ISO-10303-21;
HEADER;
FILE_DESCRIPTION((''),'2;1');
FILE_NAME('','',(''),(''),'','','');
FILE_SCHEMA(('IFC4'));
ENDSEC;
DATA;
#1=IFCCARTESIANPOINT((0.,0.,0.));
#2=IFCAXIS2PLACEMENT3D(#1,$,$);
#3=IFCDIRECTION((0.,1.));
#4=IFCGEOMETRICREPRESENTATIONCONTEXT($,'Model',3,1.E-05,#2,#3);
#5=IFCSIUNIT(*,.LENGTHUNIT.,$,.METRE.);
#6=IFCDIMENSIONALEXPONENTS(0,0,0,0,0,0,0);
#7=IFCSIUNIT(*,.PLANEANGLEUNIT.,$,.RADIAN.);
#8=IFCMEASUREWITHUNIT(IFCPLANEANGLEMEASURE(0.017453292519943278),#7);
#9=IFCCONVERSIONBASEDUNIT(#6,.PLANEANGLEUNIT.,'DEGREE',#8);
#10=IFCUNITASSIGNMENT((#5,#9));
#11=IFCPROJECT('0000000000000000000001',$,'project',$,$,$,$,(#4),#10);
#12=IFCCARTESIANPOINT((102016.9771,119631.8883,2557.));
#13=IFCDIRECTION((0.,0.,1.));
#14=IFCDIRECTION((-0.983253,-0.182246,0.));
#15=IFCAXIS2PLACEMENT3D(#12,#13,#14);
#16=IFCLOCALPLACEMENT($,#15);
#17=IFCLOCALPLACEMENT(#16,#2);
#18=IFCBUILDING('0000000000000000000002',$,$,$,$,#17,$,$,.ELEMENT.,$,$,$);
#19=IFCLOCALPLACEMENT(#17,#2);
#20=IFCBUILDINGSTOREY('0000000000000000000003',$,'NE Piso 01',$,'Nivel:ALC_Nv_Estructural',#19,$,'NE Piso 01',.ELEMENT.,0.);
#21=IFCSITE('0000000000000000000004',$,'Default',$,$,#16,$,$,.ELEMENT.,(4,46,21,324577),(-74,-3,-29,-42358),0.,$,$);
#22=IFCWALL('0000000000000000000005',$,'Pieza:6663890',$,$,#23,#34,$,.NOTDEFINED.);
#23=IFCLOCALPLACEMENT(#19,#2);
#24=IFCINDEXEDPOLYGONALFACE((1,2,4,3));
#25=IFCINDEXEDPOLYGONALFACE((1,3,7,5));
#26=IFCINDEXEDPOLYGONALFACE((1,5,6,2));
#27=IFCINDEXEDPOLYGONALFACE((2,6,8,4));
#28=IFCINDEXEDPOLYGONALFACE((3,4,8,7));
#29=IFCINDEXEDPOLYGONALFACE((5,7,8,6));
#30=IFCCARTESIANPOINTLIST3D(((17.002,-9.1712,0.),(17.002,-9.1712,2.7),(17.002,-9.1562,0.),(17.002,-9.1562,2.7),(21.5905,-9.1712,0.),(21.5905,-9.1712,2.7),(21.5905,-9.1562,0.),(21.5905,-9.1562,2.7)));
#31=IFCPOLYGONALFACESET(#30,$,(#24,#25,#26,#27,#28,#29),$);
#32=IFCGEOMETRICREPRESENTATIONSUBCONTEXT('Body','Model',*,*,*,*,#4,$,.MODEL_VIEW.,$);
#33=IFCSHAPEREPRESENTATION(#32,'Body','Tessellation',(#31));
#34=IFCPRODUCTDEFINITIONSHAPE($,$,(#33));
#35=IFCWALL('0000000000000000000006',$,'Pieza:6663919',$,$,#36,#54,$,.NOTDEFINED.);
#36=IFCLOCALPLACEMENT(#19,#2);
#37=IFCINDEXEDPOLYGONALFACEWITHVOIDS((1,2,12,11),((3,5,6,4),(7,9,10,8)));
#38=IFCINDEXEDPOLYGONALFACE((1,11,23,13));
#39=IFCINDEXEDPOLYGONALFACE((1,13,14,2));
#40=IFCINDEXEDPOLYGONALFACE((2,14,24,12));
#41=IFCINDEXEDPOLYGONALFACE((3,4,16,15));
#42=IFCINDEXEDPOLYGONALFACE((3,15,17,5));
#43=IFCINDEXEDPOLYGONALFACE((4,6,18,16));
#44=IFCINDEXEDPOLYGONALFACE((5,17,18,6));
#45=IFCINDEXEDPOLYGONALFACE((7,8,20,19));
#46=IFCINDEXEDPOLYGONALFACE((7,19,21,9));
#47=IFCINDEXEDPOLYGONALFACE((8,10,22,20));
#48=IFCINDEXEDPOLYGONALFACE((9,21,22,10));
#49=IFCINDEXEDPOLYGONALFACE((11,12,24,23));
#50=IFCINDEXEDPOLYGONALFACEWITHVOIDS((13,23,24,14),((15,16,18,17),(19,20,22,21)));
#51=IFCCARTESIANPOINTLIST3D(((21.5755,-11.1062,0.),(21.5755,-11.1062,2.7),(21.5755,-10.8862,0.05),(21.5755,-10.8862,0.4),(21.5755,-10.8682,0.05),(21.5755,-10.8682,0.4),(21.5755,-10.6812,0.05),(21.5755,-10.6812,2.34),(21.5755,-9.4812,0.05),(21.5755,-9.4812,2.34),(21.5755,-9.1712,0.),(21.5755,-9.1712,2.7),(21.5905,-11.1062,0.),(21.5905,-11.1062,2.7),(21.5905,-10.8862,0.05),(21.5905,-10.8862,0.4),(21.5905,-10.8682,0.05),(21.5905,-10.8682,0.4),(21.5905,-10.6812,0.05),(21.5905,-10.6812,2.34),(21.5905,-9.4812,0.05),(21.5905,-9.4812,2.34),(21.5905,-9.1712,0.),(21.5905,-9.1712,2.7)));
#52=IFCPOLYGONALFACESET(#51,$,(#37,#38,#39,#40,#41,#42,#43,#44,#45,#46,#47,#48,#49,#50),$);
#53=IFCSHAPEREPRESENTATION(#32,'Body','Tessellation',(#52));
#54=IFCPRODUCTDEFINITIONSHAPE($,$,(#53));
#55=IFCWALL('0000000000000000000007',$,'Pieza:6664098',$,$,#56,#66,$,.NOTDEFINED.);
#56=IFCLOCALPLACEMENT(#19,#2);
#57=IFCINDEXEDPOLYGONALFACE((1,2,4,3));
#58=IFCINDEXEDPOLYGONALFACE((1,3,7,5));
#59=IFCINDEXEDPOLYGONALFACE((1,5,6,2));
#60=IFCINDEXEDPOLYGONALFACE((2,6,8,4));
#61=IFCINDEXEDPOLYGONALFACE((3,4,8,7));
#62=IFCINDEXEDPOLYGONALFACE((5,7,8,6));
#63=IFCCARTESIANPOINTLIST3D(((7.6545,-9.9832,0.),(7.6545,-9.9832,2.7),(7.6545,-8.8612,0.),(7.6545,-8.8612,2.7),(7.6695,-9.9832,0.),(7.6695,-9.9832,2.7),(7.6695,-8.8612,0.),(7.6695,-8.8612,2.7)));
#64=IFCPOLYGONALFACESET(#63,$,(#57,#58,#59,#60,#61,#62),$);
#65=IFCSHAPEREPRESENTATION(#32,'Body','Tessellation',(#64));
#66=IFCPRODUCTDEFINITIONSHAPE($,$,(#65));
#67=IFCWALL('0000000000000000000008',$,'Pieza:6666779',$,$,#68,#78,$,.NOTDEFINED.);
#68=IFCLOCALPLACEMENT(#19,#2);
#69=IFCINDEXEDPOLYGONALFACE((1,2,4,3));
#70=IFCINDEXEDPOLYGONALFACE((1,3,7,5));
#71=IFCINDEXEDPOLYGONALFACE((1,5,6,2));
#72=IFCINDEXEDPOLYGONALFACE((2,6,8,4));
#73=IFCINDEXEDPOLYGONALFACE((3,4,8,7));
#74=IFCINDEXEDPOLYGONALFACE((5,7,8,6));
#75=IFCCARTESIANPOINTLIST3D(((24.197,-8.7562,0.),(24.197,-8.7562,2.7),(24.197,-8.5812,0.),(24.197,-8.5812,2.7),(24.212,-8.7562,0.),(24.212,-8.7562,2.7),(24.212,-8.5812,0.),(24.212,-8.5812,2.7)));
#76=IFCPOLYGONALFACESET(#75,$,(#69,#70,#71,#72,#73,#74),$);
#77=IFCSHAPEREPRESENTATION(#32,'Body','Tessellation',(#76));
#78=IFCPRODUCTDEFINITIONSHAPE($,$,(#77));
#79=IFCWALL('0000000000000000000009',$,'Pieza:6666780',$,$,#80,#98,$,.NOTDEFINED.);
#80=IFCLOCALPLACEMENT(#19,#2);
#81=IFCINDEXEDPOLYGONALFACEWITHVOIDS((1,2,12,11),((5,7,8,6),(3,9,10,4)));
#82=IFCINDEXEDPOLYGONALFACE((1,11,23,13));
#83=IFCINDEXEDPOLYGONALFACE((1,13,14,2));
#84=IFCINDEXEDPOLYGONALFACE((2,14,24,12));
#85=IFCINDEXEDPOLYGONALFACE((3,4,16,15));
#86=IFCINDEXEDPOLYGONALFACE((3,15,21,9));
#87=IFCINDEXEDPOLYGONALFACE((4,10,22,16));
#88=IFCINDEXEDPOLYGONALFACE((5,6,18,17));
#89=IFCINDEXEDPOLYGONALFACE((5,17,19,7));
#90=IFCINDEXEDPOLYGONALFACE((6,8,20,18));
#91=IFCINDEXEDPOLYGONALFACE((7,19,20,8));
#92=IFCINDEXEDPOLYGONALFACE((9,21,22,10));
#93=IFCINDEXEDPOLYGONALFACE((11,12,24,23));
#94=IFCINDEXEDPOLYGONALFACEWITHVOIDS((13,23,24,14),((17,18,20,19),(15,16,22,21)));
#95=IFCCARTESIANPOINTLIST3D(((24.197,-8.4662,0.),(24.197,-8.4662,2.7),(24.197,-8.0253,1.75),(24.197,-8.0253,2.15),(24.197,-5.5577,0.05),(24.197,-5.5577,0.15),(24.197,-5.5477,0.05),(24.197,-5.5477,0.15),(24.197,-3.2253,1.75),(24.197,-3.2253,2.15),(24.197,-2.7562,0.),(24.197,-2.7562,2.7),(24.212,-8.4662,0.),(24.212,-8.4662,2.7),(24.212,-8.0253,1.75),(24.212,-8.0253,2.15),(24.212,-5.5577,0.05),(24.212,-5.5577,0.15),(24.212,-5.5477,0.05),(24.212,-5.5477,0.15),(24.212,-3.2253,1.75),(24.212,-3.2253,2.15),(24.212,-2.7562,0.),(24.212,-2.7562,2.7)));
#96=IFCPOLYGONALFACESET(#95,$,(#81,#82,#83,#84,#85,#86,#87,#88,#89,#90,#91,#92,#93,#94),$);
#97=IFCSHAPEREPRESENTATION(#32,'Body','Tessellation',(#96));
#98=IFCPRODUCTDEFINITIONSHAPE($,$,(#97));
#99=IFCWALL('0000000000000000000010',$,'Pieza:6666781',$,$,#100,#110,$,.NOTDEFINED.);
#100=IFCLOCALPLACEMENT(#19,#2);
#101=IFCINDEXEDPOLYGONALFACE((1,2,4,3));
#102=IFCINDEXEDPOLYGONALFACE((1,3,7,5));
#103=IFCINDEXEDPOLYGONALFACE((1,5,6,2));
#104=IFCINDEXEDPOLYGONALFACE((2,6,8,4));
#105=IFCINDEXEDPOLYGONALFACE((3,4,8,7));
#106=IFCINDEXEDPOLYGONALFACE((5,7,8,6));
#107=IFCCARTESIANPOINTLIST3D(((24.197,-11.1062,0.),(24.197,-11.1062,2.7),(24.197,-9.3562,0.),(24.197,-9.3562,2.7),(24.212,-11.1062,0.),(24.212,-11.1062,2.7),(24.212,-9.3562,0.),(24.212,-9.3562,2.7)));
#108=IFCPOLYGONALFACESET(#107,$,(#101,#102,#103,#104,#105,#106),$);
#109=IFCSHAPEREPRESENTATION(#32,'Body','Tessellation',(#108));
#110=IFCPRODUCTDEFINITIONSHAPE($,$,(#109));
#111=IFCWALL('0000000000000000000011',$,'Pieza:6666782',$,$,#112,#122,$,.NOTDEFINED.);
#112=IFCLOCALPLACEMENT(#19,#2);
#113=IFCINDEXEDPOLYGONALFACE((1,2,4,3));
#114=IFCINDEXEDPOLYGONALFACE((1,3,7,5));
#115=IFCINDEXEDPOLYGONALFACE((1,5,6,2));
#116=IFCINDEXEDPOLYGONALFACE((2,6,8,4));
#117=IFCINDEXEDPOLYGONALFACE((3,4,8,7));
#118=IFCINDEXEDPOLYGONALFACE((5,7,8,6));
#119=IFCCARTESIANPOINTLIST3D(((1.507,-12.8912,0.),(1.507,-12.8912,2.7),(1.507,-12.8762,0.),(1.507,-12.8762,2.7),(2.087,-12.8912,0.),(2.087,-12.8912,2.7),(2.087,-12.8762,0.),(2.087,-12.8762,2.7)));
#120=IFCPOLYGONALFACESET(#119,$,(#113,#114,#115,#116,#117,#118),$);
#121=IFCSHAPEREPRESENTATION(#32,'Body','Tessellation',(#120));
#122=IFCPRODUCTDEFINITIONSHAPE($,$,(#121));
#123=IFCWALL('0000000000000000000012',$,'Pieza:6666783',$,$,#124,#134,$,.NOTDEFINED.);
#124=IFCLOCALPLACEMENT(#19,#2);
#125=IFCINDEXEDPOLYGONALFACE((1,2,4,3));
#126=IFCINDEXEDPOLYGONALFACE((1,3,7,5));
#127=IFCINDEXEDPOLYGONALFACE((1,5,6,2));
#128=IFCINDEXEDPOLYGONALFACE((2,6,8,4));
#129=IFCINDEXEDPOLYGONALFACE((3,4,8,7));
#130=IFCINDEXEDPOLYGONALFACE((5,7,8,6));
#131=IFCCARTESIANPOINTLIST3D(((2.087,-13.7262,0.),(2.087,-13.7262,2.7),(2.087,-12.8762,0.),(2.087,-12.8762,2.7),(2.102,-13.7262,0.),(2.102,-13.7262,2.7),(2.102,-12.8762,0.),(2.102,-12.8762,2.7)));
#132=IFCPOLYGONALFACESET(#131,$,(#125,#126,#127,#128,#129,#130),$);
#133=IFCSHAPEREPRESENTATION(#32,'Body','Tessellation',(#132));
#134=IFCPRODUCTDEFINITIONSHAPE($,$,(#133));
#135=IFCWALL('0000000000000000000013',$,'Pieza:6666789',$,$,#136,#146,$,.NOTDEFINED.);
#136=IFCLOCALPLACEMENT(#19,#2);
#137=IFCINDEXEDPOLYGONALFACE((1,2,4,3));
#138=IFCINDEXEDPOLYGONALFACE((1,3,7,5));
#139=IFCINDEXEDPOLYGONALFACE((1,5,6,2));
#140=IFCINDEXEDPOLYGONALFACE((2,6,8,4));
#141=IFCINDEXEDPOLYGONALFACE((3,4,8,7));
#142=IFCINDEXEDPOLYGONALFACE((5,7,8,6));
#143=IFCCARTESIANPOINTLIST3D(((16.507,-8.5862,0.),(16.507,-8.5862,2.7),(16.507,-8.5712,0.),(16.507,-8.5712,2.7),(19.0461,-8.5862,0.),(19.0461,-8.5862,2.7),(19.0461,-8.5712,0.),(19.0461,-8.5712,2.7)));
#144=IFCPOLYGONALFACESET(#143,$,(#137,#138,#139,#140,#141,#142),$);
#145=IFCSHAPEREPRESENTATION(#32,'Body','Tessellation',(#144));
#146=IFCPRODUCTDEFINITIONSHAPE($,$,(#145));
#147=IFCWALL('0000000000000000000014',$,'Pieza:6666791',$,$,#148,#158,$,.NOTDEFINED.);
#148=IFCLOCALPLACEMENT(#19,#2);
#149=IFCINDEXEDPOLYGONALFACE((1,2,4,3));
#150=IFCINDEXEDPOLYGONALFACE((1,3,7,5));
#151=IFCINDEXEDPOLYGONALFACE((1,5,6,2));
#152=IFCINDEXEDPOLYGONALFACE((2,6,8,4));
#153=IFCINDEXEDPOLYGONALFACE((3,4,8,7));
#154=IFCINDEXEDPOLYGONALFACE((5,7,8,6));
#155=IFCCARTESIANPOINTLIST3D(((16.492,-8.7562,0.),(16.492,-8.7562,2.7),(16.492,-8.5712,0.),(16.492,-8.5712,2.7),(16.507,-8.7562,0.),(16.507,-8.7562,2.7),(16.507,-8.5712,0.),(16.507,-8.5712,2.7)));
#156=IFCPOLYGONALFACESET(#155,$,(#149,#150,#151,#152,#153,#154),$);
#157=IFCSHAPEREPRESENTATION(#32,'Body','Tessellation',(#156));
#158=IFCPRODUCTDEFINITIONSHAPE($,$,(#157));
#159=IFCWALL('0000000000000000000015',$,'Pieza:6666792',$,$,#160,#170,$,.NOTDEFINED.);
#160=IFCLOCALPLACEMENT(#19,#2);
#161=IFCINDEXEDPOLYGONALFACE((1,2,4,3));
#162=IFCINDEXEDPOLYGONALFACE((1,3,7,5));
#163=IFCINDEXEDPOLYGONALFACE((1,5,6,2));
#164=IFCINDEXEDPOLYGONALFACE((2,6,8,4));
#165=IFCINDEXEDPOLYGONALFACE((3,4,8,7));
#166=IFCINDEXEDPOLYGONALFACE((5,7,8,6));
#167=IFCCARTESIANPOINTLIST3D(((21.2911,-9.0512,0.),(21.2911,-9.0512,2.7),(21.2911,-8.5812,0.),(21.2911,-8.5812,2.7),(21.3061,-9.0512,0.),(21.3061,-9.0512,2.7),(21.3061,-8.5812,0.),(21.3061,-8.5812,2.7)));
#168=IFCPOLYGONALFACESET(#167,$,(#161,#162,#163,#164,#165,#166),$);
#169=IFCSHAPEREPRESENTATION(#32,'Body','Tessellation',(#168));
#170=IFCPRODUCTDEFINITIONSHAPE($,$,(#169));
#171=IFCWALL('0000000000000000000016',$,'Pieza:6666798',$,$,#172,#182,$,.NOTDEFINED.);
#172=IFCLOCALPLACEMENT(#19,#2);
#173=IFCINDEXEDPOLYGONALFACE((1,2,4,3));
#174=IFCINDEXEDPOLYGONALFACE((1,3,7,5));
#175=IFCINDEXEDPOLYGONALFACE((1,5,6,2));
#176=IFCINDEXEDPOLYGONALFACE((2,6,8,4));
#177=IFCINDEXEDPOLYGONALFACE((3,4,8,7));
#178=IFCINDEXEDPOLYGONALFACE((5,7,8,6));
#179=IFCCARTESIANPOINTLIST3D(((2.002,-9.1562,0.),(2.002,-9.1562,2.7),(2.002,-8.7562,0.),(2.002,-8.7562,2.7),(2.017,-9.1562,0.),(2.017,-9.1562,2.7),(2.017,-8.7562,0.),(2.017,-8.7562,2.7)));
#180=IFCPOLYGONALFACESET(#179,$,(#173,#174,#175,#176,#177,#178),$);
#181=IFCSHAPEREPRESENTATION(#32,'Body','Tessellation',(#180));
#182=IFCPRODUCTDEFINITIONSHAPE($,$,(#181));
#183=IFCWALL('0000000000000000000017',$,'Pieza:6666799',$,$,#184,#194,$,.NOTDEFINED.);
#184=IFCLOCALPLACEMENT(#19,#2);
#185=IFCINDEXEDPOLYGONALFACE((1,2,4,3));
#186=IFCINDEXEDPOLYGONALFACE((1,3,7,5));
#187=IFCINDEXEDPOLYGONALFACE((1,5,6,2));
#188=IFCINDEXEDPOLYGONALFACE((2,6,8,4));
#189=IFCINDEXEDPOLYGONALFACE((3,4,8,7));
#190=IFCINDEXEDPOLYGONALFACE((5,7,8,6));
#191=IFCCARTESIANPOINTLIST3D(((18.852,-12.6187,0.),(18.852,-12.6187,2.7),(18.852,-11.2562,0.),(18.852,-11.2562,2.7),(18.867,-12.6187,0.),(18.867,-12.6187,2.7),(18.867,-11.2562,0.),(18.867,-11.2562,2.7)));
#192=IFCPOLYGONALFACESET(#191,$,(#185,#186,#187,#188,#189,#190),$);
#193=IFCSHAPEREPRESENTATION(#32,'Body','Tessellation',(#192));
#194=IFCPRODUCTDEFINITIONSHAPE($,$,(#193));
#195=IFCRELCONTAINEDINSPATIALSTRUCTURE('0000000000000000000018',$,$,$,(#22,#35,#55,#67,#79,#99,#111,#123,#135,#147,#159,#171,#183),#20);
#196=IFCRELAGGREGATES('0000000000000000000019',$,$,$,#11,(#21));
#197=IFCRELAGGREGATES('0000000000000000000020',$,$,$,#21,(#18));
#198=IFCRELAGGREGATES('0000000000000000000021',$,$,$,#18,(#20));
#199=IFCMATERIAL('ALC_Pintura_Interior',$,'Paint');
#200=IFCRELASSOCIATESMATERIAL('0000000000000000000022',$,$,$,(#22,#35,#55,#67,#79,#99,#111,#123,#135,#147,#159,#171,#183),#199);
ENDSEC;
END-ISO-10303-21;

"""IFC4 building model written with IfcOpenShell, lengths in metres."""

from ifc_helpers import new_model, entity, si_unit, converted_unit, direction, frame, frame_2d, origin, place, context, subcontext, project, spatial, rectangle, extrude, boolean, material, element, save


model = new_model("IFC4")

# Units and contexts
model_context = context("Model", 3, precision=1e-05, world=origin(), true_north=direction((0.0, 1.0)))
body_context = subcontext(model_context, "Body", "Model", "MODEL_VIEW")
ifc_project = project(units=[si_unit("LENGTHUNIT", "METRE"), converted_unit("PLANEANGLEUNIT", "DEGREE", entity("IfcPlaneAngleMeasure", 0.017453292519943278), si_unit("PLANEANGLEUNIT", "RADIAN"), dimensions=[0, 0, 0, 0, 0, 0, 0])], contexts=[model_context])

# Site, building, storey
site_placement = place(None, frame((102016.9771, 119631.8883, 2557.0), z_axis=(0.0, 0.0, 1.0), x_axis=(-0.983253, -0.182246, 0.0)))
site = spatial("IfcSite", under=ifc_project, at=site_placement, Name="Default", CompositionType="ELEMENT", RefLatitude=(4, 46, 21, 324577), RefLongitude=(-74, -3, -29, -42358), RefElevation=0.0)
building_placement = place(site_placement, origin())
building = spatial("IfcBuilding", under=site, at=building_placement, CompositionType="ELEMENT")
storey_placement = place(building_placement, origin())
storey = spatial("IfcBuildingStorey", under=building, at=storey_placement, Name="NE Piso 01", ObjectType="Nivel:ALC_Nv_Estructural", LongName="NE Piso 01", CompositionType="ELEMENT", Elevation=0.0)

# Walls
ifc_material_1 = material(Name="ALC_Pintura_Interior", Category="Paint")
wall_1_placement = place(storey_placement, origin())
element("IfcWall", 1, at=wall_1_placement, inside=storey, material=ifc_material_1, Name="Pieza:6663890", PredefinedType="NOTDEFINED", context=body_context, shape_type="SweptSolid", body=[
    extrude(rectangle(XDim=0.015, YDim=4.5885, at=frame_2d((0.0, 0.0), x_axis=(1.0, 0.0))), frame((19.2963, -9.1637, 0.0), z_axis=(0.0, 0.0, 1.0), x_axis=(0.0, -1.0, 0.0)), (0.0, 0.0, 1.0), 2.7),
])
wall_2_placement = place(storey_placement, origin())
element("IfcWall", 2, at=wall_2_placement, inside=storey, material=ifc_material_1, Name="Pieza:6663919", PredefinedType="NOTDEFINED", context=body_context, shape_type="SweptSolid", body=[
    boolean("DIFFERENCE", boolean("DIFFERENCE", extrude(rectangle(XDim=0.015, YDim=1.935, at=frame_2d((0.0, 0.0), x_axis=(1.0, 0.0))), frame((21.583, -10.1387, 0.0)), (0.0, 0.0, 1.0), 2.7), extrude(rectangle(XDim=0.35, YDim=0.018, at=frame_2d((0.0, 0.0), x_axis=(0.0, 1.0))), frame((21.5755, -10.8772, 0.225), z_axis=(1.0, 0.0, 0.0), x_axis=(0.0, -1.0, 0.0)), (0.0, 0.0, 1.0), 0.015)), extrude(rectangle(XDim=2.29, YDim=1.2, at=frame_2d((0.0, 0.0), x_axis=(0.0, 1.0))), frame((21.5755, -10.0812, 1.195), z_axis=(-1.0, 0.0, 0.0), x_axis=(0.0, 1.0, 0.0)), (0.0, 0.0, -1.0), 0.015)),
])
wall_3_placement = place(storey_placement, origin())
element("IfcWall", 3, at=wall_3_placement, inside=storey, material=ifc_material_1, Name="Pieza:6664098", PredefinedType="NOTDEFINED", context=body_context, shape_type="SweptSolid", body=[
    extrude(rectangle(XDim=1.122, YDim=0.015, at=frame_2d((0.0, 0.0), x_axis=(1.0, 0.0))), frame((7.662, -9.4222, 0.0), z_axis=(0.0, 0.0, 1.0), x_axis=(0.0, -1.0, 0.0)), (0.0, 0.0, 1.0), 2.7),
])
wall_4_placement = place(storey_placement, origin())
element("IfcWall", 4, at=wall_4_placement, inside=storey, material=ifc_material_1, Name="Pieza:6666779", PredefinedType="NOTDEFINED", context=body_context, shape_type="SweptSolid", body=[
    extrude(rectangle(XDim=0.175, YDim=0.015, at=frame_2d((0.0, 0.0), x_axis=(1.0, 0.0))), frame((24.2045, -8.6687, 0.0), z_axis=(0.0, 0.0, 1.0), x_axis=(0.0, -1.0, 0.0)), (0.0, 0.0, 1.0), 2.7),
])
wall_5_placement = place(storey_placement, origin())
element("IfcWall", 5, at=wall_5_placement, inside=storey, material=ifc_material_1, Name="Pieza:6666780", PredefinedType="NOTDEFINED", context=body_context, shape_type="SweptSolid", body=[
    boolean("DIFFERENCE", boolean("DIFFERENCE", extrude(rectangle(XDim=0.015, YDim=5.71, at=frame_2d((0.0, 0.0), x_axis=(1.0, 0.0))), frame((24.2045, -5.6112, 0.0)), (0.0, 0.0, 1.0), 2.7), extrude(rectangle(XDim=0.1, YDim=0.01, at=frame_2d((0.0, 0.0), x_axis=(0.0, 1.0))), frame((24.212, -5.5527, 0.1), z_axis=(-1.0, 0.0, 0.0), x_axis=(0.0, 1.0, 0.0)), (0.0, 0.0, 1.0), 0.015)), extrude(rectangle(XDim=0.4, YDim=4.8, at=frame_2d((0.0, 0.0), x_axis=(0.0, 1.0))), frame((24.212, -5.6253, 1.95), z_axis=(-1.0, 0.0, 0.0), x_axis=(0.0, 1.0, 0.0)), (0.0, 0.0, 1.0), 0.015)),
])
wall_6_placement = place(storey_placement, origin())
element("IfcWall", 6, at=wall_6_placement, inside=storey, material=ifc_material_1, Name="Pieza:6666781", PredefinedType="NOTDEFINED", context=body_context, shape_type="SweptSolid", body=[
    extrude(rectangle(XDim=1.75, YDim=0.015, at=frame_2d((0.0, 0.0), x_axis=(1.0, 0.0))), frame((24.2045, -10.2312, 0.0), z_axis=(0.0, 0.0, 1.0), x_axis=(0.0, -1.0, 0.0)), (0.0, 0.0, 1.0), 2.7),
])
wall_7_placement = place(storey_placement, origin())
element("IfcWall", 7, at=wall_7_placement, inside=storey, material=ifc_material_1, Name="Pieza:6666782", PredefinedType="NOTDEFINED", context=body_context, shape_type="SweptSolid", body=[
    extrude(rectangle(XDim=0.015, YDim=0.58, at=frame_2d((0.0, 0.0), x_axis=(1.0, 0.0))), frame((1.797, -12.8837, 0.0), z_axis=(0.0, 0.0, 1.0), x_axis=(0.0, -1.0, 0.0)), (0.0, 0.0, 1.0), 2.7),
])
wall_8_placement = place(storey_placement, origin())
element("IfcWall", 8, at=wall_8_placement, inside=storey, material=ifc_material_1, Name="Pieza:6666783", PredefinedType="NOTDEFINED", context=body_context, shape_type="SweptSolid", body=[
    extrude(rectangle(XDim=0.85, YDim=0.015, at=frame_2d((0.0, 0.0), x_axis=(1.0, 0.0))), frame((2.0945, -13.3012, 0.0), z_axis=(0.0, 0.0, 1.0), x_axis=(0.0, -1.0, 0.0)), (0.0, 0.0, 1.0), 2.7),
])
wall_9_placement = place(storey_placement, origin())
element("IfcWall", 9, at=wall_9_placement, inside=storey, material=ifc_material_1, Name="Pieza:6666789", PredefinedType="NOTDEFINED", context=body_context, shape_type="SweptSolid", body=[
    extrude(rectangle(XDim=0.015, YDim=2.5391, at=frame_2d((0.0, 0.0), x_axis=(1.0, 0.0))), frame((17.7766, -8.5787, 0.0), z_axis=(0.0, 0.0, 1.0), x_axis=(0.0, -1.0, 0.0)), (0.0, 0.0, 1.0), 2.7),
])
wall_10_placement = place(storey_placement, origin())
element("IfcWall", 10, at=wall_10_placement, inside=storey, material=ifc_material_1, Name="Pieza:6666791", PredefinedType="NOTDEFINED", context=body_context, shape_type="SweptSolid", body=[
    extrude(rectangle(XDim=0.185, YDim=0.015, at=frame_2d((0.0, 0.0), x_axis=(1.0, 0.0))), frame((16.4995, -8.6637, 0.0), z_axis=(0.0, 0.0, 1.0), x_axis=(0.0, -1.0, 0.0)), (0.0, 0.0, 1.0), 2.7),
])
wall_11_placement = place(storey_placement, origin())
element("IfcWall", 11, at=wall_11_placement, inside=storey, material=ifc_material_1, Name="Pieza:6666792", PredefinedType="NOTDEFINED", context=body_context, shape_type="SweptSolid", body=[
    extrude(rectangle(XDim=0.47, YDim=0.015, at=frame_2d((0.0, 0.0), x_axis=(1.0, 0.0))), frame((21.2986, -8.8162, 0.0), z_axis=(0.0, 0.0, 1.0), x_axis=(0.0, -1.0, 0.0)), (0.0, 0.0, 1.0), 2.7),
])
wall_12_placement = place(storey_placement, origin())
element("IfcWall", 12, at=wall_12_placement, inside=storey, material=ifc_material_1, Name="Pieza:6666798", PredefinedType="NOTDEFINED", context=body_context, shape_type="SweptSolid", body=[
    extrude(rectangle(XDim=0.4, YDim=0.015, at=frame_2d((0.0, 0.0), x_axis=(1.0, 0.0))), frame((2.0095, -8.9562, 0.0), z_axis=(0.0, 0.0, 1.0), x_axis=(0.0, -1.0, 0.0)), (0.0, 0.0, 1.0), 2.7),
])
wall_13_placement = place(storey_placement, origin())
element("IfcWall", 13, at=wall_13_placement, inside=storey, material=ifc_material_1, Name="Pieza:6666799", PredefinedType="NOTDEFINED", context=body_context, shape_type="SweptSolid", body=[
    extrude(rectangle(XDim=1.3625, YDim=0.015, at=frame_2d((0.0, 0.0), x_axis=(1.0, 0.0))), frame((18.8595, -11.9374, 0.0), z_axis=(0.0, 0.0, 1.0), x_axis=(0.0, -1.0, 0.0)), (0.0, 0.0, 1.0), 2.7),
])

save(model, "model.ifc")
